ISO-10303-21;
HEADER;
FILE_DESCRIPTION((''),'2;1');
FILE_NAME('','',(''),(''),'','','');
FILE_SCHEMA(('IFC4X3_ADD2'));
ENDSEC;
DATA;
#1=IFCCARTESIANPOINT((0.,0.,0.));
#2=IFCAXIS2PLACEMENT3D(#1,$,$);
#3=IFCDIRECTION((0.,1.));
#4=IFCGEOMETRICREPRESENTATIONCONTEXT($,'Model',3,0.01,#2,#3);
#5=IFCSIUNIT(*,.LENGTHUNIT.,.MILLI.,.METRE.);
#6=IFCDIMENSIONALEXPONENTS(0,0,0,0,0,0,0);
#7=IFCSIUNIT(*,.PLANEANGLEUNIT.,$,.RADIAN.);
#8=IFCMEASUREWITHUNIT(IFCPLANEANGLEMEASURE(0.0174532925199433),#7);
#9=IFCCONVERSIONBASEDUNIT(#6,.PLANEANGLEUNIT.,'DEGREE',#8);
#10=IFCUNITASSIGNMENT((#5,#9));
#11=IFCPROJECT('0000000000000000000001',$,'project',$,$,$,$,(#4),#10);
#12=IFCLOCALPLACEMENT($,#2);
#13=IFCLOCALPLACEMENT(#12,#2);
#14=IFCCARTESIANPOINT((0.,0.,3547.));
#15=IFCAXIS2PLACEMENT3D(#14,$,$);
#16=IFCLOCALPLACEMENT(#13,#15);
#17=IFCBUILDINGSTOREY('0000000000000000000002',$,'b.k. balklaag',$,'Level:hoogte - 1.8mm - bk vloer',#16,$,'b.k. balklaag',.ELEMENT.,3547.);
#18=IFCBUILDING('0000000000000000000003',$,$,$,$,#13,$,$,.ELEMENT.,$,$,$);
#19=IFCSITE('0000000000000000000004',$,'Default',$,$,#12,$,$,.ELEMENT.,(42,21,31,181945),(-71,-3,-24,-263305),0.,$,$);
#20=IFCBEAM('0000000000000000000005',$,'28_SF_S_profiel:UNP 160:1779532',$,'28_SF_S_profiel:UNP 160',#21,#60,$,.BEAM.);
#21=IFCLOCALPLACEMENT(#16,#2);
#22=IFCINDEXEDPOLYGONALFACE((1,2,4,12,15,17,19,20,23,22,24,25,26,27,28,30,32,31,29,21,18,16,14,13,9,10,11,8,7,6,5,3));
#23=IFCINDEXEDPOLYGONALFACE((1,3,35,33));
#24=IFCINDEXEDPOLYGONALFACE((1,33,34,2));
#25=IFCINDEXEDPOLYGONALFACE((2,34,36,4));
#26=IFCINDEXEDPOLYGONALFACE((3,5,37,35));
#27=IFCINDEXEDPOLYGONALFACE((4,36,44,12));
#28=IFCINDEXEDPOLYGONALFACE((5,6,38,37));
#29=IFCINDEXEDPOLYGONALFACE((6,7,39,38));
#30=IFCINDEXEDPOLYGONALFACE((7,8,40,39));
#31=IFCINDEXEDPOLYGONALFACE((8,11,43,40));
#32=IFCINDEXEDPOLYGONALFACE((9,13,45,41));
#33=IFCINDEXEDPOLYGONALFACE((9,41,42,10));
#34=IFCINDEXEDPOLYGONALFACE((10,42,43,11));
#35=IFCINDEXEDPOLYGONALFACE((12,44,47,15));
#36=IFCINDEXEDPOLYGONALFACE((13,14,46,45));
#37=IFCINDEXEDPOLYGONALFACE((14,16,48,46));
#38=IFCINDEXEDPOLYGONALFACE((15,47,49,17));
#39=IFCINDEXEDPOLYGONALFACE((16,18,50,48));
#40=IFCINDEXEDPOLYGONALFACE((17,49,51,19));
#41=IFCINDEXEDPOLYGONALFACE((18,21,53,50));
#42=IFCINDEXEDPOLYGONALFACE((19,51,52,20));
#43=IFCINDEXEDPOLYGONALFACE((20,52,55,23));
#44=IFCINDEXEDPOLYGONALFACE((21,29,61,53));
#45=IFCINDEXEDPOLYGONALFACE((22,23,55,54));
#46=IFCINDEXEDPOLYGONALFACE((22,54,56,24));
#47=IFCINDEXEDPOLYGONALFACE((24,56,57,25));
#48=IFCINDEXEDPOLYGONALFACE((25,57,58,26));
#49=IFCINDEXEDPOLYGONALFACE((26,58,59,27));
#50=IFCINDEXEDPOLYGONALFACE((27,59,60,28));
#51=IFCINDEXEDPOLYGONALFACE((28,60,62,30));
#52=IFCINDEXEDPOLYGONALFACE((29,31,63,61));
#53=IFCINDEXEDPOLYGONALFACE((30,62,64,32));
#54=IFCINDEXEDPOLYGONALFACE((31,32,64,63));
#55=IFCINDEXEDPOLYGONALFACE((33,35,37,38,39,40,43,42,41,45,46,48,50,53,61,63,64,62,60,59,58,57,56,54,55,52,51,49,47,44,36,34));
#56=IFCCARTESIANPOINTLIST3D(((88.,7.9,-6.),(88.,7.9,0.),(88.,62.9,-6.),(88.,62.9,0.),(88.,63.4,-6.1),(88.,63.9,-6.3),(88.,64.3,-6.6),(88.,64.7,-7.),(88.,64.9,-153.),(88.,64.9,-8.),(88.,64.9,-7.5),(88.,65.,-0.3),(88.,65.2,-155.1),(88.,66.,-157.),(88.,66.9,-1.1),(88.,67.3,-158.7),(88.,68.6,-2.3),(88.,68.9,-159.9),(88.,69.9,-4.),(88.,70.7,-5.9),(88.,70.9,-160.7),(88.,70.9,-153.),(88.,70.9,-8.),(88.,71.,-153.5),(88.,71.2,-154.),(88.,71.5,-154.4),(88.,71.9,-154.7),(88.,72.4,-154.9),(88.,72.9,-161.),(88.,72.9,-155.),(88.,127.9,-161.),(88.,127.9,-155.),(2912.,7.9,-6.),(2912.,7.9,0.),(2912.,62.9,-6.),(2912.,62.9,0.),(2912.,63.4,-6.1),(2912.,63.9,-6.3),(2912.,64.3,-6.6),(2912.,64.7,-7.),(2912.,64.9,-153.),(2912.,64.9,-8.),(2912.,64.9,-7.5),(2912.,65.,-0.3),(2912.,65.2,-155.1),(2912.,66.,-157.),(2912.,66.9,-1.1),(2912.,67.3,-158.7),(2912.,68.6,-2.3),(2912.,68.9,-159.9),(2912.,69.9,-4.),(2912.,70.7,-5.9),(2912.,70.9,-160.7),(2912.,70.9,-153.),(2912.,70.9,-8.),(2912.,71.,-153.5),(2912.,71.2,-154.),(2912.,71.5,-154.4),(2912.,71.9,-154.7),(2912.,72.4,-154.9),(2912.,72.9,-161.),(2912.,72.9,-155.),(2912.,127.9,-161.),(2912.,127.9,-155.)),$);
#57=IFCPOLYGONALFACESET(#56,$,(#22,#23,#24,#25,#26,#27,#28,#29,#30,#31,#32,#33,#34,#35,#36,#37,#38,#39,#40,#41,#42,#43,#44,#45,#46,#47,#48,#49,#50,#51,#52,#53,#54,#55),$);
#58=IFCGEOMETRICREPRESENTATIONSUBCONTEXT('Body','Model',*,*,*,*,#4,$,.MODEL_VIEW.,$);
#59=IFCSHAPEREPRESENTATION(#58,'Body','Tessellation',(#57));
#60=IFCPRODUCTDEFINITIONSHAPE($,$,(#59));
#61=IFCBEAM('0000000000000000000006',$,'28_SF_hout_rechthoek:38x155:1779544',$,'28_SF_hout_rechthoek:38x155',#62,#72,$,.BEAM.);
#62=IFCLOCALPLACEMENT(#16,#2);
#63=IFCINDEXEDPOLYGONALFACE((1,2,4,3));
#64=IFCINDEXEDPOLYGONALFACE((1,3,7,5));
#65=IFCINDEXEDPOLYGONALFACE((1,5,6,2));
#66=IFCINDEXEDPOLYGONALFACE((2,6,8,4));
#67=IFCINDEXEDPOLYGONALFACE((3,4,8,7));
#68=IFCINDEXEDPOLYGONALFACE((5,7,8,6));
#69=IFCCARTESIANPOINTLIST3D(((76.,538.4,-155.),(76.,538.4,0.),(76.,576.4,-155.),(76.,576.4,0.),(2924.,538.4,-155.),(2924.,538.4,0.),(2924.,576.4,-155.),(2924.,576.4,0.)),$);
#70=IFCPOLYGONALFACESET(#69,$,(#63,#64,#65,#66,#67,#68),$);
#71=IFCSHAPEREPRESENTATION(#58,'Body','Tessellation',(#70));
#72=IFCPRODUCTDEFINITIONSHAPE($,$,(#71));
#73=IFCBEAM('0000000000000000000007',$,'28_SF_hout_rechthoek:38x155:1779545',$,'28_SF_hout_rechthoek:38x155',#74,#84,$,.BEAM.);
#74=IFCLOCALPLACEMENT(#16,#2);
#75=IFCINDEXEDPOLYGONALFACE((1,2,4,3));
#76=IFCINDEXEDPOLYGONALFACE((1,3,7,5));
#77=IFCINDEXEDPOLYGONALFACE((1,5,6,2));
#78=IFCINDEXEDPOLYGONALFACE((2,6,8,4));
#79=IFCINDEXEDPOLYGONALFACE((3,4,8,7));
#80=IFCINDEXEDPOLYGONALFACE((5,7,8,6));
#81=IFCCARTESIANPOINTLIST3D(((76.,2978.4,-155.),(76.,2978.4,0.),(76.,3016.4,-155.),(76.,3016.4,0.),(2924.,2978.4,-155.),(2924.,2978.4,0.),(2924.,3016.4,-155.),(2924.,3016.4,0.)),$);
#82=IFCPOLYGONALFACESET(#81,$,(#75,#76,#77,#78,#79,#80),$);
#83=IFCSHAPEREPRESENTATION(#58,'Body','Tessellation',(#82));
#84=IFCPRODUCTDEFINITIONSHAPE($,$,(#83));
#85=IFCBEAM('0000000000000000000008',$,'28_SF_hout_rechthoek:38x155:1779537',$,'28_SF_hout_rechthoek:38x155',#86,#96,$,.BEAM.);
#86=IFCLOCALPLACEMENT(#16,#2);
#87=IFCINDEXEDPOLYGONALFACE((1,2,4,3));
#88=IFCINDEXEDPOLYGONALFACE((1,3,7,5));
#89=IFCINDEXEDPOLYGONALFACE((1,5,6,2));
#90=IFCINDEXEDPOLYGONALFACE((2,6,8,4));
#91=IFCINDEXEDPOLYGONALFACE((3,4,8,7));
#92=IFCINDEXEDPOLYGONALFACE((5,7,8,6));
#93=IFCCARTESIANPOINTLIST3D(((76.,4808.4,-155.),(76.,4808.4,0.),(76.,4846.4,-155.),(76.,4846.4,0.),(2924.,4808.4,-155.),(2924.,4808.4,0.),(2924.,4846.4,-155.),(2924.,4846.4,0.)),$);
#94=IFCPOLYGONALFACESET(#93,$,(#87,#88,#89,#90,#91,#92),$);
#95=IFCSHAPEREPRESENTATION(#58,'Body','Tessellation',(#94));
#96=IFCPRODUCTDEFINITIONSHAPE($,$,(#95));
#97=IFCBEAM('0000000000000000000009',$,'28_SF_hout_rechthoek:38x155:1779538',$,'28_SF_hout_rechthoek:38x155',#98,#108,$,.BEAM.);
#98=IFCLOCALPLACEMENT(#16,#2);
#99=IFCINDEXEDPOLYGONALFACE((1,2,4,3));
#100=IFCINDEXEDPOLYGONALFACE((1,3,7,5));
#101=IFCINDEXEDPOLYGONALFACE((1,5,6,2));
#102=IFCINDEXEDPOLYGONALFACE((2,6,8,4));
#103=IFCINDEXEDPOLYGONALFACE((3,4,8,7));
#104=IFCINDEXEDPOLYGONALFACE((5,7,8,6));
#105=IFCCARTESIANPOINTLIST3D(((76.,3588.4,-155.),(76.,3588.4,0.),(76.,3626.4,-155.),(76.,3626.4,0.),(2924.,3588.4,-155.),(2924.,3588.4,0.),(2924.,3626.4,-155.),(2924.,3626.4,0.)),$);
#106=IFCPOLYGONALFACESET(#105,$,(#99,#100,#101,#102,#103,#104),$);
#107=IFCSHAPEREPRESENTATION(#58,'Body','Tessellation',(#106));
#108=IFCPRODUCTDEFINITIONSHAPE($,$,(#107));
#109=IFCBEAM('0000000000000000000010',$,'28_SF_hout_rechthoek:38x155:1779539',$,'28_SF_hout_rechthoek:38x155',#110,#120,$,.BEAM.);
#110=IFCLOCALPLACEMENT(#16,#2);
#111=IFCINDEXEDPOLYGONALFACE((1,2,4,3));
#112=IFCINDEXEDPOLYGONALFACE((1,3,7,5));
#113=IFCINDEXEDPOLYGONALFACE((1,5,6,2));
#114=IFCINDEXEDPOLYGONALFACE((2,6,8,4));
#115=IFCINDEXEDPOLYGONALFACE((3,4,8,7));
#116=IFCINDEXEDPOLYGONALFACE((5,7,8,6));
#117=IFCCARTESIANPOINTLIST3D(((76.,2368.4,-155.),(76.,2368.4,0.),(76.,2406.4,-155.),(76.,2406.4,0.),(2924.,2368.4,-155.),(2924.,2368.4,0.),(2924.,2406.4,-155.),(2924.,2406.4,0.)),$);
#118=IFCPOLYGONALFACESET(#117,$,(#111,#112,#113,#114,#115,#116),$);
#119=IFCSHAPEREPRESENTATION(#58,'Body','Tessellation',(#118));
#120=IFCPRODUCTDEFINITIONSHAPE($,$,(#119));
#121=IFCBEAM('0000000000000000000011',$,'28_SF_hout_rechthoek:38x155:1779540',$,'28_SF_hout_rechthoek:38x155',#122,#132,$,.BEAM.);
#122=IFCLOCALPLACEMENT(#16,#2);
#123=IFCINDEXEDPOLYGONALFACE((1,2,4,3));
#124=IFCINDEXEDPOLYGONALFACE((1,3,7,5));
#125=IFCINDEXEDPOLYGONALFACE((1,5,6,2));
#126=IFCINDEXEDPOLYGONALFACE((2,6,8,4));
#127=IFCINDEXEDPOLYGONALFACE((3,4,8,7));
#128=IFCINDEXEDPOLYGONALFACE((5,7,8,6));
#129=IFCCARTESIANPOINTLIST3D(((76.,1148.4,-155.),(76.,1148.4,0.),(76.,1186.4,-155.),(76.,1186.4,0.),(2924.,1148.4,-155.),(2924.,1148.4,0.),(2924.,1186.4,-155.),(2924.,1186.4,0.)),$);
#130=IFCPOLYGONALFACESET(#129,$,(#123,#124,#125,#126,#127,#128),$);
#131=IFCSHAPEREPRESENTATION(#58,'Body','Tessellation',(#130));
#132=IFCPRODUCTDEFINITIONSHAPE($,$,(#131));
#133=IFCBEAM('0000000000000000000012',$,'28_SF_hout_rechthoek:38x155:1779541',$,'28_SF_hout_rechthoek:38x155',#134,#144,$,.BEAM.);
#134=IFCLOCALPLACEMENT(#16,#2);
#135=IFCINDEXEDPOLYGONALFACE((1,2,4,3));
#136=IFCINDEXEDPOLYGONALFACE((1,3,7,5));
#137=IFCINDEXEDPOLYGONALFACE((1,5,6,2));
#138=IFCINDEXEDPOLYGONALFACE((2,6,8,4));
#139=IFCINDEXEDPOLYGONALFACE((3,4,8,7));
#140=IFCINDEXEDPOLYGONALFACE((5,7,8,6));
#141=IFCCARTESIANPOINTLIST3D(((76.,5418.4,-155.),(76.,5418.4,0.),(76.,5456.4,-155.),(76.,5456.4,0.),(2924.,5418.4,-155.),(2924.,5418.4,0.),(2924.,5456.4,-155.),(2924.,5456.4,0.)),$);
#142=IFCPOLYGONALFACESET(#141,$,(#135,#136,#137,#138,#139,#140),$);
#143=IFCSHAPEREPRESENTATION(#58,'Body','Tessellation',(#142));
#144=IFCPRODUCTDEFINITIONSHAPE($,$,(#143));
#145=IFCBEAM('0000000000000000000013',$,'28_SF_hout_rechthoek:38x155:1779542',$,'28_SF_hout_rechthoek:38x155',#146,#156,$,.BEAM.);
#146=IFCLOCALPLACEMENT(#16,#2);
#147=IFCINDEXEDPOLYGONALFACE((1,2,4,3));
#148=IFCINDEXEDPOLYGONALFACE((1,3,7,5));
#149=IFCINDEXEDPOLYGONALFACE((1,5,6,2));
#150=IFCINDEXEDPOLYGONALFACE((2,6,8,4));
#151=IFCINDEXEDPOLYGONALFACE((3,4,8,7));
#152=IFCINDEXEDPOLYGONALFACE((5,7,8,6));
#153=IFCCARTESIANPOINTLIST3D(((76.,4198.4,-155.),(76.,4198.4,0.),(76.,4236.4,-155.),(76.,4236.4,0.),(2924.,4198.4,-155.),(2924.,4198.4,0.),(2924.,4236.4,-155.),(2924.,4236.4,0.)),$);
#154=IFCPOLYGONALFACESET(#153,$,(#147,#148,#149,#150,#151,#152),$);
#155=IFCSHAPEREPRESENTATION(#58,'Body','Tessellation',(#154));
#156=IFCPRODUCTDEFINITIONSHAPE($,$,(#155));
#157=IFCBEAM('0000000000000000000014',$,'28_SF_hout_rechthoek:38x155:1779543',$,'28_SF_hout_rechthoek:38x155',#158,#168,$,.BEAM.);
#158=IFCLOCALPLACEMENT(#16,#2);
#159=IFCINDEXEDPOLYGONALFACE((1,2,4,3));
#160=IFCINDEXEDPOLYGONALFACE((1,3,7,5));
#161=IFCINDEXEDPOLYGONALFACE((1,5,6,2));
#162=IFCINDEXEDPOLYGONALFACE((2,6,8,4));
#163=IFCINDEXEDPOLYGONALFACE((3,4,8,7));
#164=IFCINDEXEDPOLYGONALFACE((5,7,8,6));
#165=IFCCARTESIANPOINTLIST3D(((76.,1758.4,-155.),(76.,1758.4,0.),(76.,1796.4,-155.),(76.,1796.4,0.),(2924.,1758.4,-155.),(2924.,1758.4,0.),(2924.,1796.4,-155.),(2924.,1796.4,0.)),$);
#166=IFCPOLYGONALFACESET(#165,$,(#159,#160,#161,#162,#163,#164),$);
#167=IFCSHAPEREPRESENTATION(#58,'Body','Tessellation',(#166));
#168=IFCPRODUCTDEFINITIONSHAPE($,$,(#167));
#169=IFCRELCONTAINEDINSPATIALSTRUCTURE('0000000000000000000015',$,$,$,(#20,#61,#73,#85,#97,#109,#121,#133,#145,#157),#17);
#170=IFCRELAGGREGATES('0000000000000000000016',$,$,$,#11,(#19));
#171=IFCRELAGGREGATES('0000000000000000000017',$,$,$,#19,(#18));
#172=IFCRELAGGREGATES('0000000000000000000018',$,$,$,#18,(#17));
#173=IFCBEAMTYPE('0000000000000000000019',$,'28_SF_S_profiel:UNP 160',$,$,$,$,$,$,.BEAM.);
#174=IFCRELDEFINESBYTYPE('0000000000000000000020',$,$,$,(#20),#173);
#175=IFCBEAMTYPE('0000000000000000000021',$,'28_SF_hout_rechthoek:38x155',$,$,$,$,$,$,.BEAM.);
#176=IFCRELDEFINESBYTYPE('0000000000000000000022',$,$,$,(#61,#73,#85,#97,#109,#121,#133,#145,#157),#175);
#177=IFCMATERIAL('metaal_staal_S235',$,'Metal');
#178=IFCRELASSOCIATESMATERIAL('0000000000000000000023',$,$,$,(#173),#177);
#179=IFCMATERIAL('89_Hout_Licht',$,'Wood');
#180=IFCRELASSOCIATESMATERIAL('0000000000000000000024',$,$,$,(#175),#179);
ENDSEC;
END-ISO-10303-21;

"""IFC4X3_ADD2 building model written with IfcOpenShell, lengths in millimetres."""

from ifc_helpers import new_model, entity, si_unit, converted_unit, direction, frame, frame_2d, origin, origin_2d_with_axis, place, context, subcontext, project, spatial, polyline, circle_curve, parameter, trimmed, segment, composite_curve, rectangle, outline, extrude, source, transform, mapped, material, material_profile, profile_set, type_object, type_shapes, element, save


model = new_model("IFC4X3_ADD2")

# Units and contexts
model_context = context("Model", 3, precision=0.01, world=origin(), true_north=direction((0.0, 1.0)))
body_context = subcontext(model_context, "Body", "Model", "MODEL_VIEW")
ifc_project = project(units=[si_unit("LENGTHUNIT", "METRE", prefix="MILLI"), converted_unit("PLANEANGLEUNIT", "DEGREE", entity("IfcPlaneAngleMeasure", 0.0174532925199433), si_unit("PLANEANGLEUNIT", "RADIAN"), dimensions=[0, 0, 0, 0, 0, 0, 0])], contexts=[model_context])

# Site, building, storey
site_placement = place(None, origin())
site = spatial("IfcSite", under=ifc_project, at=site_placement, Name="Default", CompositionType="ELEMENT", RefLatitude=(42, 21, 31, 181945), RefLongitude=(-71, -3, -24, -263305), RefElevation=0.0)
building_placement = place(site_placement, origin())
building = spatial("IfcBuilding", under=site, at=building_placement, CompositionType="ELEMENT")
storey_placement = place(building_placement, frame((0.0, 0.0, 3547.0)))
storey = spatial("IfcBuildingStorey", under=building, at=storey_placement, Name="b.k. balklaag", ObjectType="Level:hoogte - 1.8mm - bk vloer", LongName="b.k. balklaag", CompositionType="ELEMENT", Elevation=3547.0)

# Beams
ifc_material_1 = material(Name="metaal_staal_S235", Category="Metal")
ifc_material_profile_1 = material_profile(ifc_material_1, outline(composite_curve([segment(polyline([(-80.5, -60.0), (-74.5, -60.0)]), True, "CONTINUOUS"), segment(polyline([(-74.5, -60.0), (-74.5, -5.0)]), True, "CONTINUOUS"), segment(trimmed(circle_curve(frame_2d((-72.5, -5.0), x_axis=(0.0, -1.0)), 2.0), [parameter(180.0)], [parameter(270.0)], True, "PARAMETER"), False, "CONTINUOUS"), segment(polyline([(-72.5, -3.0), (72.5, -3.0)]), True, "CONTINUOUS"), segment(trimmed(circle_curve(frame_2d((72.5, 5.0), x_axis=(0.0, -1.0)), 8.0), [parameter(0.0)], [parameter(90.0)], True, "PARAMETER"), True, "CONTINUOUS"), segment(polyline([(80.5, 5.0), (80.5, 60.0)]), True, "CONTINUOUS"), segment(polyline([(80.5, 60.0), (74.5, 60.0)]), True, "CONTINUOUS"), segment(polyline([(74.5, 60.0), (74.5, 5.0)]), True, "CONTINUOUS"), segment(trimmed(circle_curve(frame_2d((72.5, 5.0), x_axis=(0.0, -1.0)), 2.0), [parameter(0.0)], [parameter(90.0)], True, "PARAMETER"), False, "CONTINUOUS"), segment(polyline([(72.5, 3.0), (-72.5, 3.0)]), True, "CONTINUOUS"), segment(trimmed(circle_curve(frame_2d((-72.5, -5.0), x_axis=(0.0, -1.0)), 8.0), [parameter(180.0)], [parameter(270.0)], True, "PARAMETER"), True, "CONTINUOUS"), segment(polyline([(-80.5, -5.0), (-80.5, -60.0)]), True, "CONTINUOUS")], self_intersect=False)), Name="UNP 160")
ifc_profile_set_1 = profile_set([ifc_material_profile_1], Name="UNP 160")
beam_type_1 = type_object("IfcBeamType", Name="28_SF_S_profiel:UNP 160", PredefinedType="BEAM", material=ifc_profile_set_1)
shared_shape_1 = source(origin(), body_context, "Body", "SweptSolid", [
    extrude(outline(composite_curve([segment(polyline([(-80.5, -60.0), (-74.5, -60.0)]), True, "CONTINUOUS"), segment(polyline([(-74.5, -60.0), (-74.5, -5.0)]), True, "CONTINUOUS"), segment(trimmed(circle_curve(frame_2d((-72.5, -5.0), x_axis=(0.0, -1.0)), 2.0), [parameter(180.0)], [parameter(270.0)], True, "PARAMETER"), False, "CONTINUOUS"), segment(polyline([(-72.5, -3.0), (72.5, -3.0)]), True, "CONTINUOUS"), segment(trimmed(circle_curve(frame_2d((72.5, 5.0), x_axis=(0.0, -1.0)), 8.0), [parameter(0.0)], [parameter(90.0)], True, "PARAMETER"), True, "CONTINUOUS"), segment(polyline([(80.5, 5.0), (80.5, 60.0)]), True, "CONTINUOUS"), segment(polyline([(80.5, 60.0), (74.5, 60.0)]), True, "CONTINUOUS"), segment(polyline([(74.5, 60.0), (74.5, 5.0)]), True, "CONTINUOUS"), segment(trimmed(circle_curve(frame_2d((72.5, 5.0), x_axis=(0.0, -1.0)), 2.0), [parameter(0.0)], [parameter(90.0)], True, "PARAMETER"), False, "CONTINUOUS"), segment(polyline([(72.5, 3.0), (-72.5, 3.0)]), True, "CONTINUOUS"), segment(trimmed(circle_curve(frame_2d((-72.5, -5.0), x_axis=(0.0, -1.0)), 8.0), [parameter(180.0)], [parameter(270.0)], True, "PARAMETER"), True, "CONTINUOUS"), segment(polyline([(-80.5, -5.0), (-80.5, -60.0)]), True, "CONTINUOUS")], self_intersect=False)), frame((-1412.0, 49.0, -4.5), z_axis=(1.0, 0.0, 0.0), x_axis=(0.0, 0.0, -1.0)), (0.0, 0.0, 1.0), 2824.0),
])
type_shapes(beam_type_1, [shared_shape_1])
beam_1_placement = place(storey_placement, frame((1500.0, 18.9, -76.0)))
element("IfcBeam", 1, at=beam_1_placement, inside=storey, type_object=beam_type_1, Name="28_SF_S_profiel:UNP 160:1779532", ObjectType="28_SF_S_profiel:UNP 160", PredefinedType="BEAM", context=body_context, shape_type="MappedRepresentation", body=[
    mapped(shared_shape_1, transform((0.0, 0.0, 0.0), scale=1.0)),
])
ifc_material_2 = material(Name="89_Hout_Licht", Category="Wood")
ifc_material_profile_2 = material_profile(ifc_material_2, rectangle(XDim=2848.0, YDim=38.0, at=origin_2d_with_axis()), Name="38x155")
ifc_profile_set_2 = profile_set([ifc_material_profile_2], Name="38x155")
beam_type_2 = type_object("IfcBeamType", Name="28_SF_hout_rechthoek:38x155", PredefinedType="BEAM", material=ifc_profile_set_2)
shared_shape_2 = source(origin(), body_context, "Body", "SweptSolid", [
    extrude(rectangle(XDim=2848.0, YDim=38.0, at=origin_2d_with_axis()), frame((0.0, 0.0, -77.5), z_axis=(0.0, 0.0, 1.0), x_axis=(-1.0, 0.0, 0.0)), (0.0, 0.0, 1.0), 155.0),
])
type_shapes(beam_type_2, [shared_shape_2])
for number, where, name in (
    (2, (1500.0, 557.4, -77.5), "28_SF_hout_rechthoek:38x155:1779544"),
    (3, (1500.0, 2997.4, -77.5), "28_SF_hout_rechthoek:38x155:1779545"),
    (4, (1500.0, 4827.4, -77.5), "28_SF_hout_rechthoek:38x155:1779537"),
    (5, (1500.0, 3607.4, -77.5), "28_SF_hout_rechthoek:38x155:1779538"),
    (6, (1500.0, 2387.4, -77.5), "28_SF_hout_rechthoek:38x155:1779539"),
    (7, (1500.0, 1167.4, -77.5), "28_SF_hout_rechthoek:38x155:1779540"),
    (8, (1500.0, 5437.4, -77.5), "28_SF_hout_rechthoek:38x155:1779541"),
    (9, (1500.0, 4217.4, -77.5), "28_SF_hout_rechthoek:38x155:1779542"),
    (10, (1500.0, 1777.4, -77.5), "28_SF_hout_rechthoek:38x155:1779543"),
):
    element("IfcBeam", number, at=place(storey_placement, frame(where)), inside=storey, type_object=beam_type_2, Name=name, ObjectType="28_SF_hout_rechthoek:38x155", PredefinedType="BEAM", context=body_context, shape_type="MappedRepresentation", body=[
        mapped(shared_shape_2, transform((0.0, 0.0, 0.0), scale=1.0)),
    ])

save(model, "model.ifc")
